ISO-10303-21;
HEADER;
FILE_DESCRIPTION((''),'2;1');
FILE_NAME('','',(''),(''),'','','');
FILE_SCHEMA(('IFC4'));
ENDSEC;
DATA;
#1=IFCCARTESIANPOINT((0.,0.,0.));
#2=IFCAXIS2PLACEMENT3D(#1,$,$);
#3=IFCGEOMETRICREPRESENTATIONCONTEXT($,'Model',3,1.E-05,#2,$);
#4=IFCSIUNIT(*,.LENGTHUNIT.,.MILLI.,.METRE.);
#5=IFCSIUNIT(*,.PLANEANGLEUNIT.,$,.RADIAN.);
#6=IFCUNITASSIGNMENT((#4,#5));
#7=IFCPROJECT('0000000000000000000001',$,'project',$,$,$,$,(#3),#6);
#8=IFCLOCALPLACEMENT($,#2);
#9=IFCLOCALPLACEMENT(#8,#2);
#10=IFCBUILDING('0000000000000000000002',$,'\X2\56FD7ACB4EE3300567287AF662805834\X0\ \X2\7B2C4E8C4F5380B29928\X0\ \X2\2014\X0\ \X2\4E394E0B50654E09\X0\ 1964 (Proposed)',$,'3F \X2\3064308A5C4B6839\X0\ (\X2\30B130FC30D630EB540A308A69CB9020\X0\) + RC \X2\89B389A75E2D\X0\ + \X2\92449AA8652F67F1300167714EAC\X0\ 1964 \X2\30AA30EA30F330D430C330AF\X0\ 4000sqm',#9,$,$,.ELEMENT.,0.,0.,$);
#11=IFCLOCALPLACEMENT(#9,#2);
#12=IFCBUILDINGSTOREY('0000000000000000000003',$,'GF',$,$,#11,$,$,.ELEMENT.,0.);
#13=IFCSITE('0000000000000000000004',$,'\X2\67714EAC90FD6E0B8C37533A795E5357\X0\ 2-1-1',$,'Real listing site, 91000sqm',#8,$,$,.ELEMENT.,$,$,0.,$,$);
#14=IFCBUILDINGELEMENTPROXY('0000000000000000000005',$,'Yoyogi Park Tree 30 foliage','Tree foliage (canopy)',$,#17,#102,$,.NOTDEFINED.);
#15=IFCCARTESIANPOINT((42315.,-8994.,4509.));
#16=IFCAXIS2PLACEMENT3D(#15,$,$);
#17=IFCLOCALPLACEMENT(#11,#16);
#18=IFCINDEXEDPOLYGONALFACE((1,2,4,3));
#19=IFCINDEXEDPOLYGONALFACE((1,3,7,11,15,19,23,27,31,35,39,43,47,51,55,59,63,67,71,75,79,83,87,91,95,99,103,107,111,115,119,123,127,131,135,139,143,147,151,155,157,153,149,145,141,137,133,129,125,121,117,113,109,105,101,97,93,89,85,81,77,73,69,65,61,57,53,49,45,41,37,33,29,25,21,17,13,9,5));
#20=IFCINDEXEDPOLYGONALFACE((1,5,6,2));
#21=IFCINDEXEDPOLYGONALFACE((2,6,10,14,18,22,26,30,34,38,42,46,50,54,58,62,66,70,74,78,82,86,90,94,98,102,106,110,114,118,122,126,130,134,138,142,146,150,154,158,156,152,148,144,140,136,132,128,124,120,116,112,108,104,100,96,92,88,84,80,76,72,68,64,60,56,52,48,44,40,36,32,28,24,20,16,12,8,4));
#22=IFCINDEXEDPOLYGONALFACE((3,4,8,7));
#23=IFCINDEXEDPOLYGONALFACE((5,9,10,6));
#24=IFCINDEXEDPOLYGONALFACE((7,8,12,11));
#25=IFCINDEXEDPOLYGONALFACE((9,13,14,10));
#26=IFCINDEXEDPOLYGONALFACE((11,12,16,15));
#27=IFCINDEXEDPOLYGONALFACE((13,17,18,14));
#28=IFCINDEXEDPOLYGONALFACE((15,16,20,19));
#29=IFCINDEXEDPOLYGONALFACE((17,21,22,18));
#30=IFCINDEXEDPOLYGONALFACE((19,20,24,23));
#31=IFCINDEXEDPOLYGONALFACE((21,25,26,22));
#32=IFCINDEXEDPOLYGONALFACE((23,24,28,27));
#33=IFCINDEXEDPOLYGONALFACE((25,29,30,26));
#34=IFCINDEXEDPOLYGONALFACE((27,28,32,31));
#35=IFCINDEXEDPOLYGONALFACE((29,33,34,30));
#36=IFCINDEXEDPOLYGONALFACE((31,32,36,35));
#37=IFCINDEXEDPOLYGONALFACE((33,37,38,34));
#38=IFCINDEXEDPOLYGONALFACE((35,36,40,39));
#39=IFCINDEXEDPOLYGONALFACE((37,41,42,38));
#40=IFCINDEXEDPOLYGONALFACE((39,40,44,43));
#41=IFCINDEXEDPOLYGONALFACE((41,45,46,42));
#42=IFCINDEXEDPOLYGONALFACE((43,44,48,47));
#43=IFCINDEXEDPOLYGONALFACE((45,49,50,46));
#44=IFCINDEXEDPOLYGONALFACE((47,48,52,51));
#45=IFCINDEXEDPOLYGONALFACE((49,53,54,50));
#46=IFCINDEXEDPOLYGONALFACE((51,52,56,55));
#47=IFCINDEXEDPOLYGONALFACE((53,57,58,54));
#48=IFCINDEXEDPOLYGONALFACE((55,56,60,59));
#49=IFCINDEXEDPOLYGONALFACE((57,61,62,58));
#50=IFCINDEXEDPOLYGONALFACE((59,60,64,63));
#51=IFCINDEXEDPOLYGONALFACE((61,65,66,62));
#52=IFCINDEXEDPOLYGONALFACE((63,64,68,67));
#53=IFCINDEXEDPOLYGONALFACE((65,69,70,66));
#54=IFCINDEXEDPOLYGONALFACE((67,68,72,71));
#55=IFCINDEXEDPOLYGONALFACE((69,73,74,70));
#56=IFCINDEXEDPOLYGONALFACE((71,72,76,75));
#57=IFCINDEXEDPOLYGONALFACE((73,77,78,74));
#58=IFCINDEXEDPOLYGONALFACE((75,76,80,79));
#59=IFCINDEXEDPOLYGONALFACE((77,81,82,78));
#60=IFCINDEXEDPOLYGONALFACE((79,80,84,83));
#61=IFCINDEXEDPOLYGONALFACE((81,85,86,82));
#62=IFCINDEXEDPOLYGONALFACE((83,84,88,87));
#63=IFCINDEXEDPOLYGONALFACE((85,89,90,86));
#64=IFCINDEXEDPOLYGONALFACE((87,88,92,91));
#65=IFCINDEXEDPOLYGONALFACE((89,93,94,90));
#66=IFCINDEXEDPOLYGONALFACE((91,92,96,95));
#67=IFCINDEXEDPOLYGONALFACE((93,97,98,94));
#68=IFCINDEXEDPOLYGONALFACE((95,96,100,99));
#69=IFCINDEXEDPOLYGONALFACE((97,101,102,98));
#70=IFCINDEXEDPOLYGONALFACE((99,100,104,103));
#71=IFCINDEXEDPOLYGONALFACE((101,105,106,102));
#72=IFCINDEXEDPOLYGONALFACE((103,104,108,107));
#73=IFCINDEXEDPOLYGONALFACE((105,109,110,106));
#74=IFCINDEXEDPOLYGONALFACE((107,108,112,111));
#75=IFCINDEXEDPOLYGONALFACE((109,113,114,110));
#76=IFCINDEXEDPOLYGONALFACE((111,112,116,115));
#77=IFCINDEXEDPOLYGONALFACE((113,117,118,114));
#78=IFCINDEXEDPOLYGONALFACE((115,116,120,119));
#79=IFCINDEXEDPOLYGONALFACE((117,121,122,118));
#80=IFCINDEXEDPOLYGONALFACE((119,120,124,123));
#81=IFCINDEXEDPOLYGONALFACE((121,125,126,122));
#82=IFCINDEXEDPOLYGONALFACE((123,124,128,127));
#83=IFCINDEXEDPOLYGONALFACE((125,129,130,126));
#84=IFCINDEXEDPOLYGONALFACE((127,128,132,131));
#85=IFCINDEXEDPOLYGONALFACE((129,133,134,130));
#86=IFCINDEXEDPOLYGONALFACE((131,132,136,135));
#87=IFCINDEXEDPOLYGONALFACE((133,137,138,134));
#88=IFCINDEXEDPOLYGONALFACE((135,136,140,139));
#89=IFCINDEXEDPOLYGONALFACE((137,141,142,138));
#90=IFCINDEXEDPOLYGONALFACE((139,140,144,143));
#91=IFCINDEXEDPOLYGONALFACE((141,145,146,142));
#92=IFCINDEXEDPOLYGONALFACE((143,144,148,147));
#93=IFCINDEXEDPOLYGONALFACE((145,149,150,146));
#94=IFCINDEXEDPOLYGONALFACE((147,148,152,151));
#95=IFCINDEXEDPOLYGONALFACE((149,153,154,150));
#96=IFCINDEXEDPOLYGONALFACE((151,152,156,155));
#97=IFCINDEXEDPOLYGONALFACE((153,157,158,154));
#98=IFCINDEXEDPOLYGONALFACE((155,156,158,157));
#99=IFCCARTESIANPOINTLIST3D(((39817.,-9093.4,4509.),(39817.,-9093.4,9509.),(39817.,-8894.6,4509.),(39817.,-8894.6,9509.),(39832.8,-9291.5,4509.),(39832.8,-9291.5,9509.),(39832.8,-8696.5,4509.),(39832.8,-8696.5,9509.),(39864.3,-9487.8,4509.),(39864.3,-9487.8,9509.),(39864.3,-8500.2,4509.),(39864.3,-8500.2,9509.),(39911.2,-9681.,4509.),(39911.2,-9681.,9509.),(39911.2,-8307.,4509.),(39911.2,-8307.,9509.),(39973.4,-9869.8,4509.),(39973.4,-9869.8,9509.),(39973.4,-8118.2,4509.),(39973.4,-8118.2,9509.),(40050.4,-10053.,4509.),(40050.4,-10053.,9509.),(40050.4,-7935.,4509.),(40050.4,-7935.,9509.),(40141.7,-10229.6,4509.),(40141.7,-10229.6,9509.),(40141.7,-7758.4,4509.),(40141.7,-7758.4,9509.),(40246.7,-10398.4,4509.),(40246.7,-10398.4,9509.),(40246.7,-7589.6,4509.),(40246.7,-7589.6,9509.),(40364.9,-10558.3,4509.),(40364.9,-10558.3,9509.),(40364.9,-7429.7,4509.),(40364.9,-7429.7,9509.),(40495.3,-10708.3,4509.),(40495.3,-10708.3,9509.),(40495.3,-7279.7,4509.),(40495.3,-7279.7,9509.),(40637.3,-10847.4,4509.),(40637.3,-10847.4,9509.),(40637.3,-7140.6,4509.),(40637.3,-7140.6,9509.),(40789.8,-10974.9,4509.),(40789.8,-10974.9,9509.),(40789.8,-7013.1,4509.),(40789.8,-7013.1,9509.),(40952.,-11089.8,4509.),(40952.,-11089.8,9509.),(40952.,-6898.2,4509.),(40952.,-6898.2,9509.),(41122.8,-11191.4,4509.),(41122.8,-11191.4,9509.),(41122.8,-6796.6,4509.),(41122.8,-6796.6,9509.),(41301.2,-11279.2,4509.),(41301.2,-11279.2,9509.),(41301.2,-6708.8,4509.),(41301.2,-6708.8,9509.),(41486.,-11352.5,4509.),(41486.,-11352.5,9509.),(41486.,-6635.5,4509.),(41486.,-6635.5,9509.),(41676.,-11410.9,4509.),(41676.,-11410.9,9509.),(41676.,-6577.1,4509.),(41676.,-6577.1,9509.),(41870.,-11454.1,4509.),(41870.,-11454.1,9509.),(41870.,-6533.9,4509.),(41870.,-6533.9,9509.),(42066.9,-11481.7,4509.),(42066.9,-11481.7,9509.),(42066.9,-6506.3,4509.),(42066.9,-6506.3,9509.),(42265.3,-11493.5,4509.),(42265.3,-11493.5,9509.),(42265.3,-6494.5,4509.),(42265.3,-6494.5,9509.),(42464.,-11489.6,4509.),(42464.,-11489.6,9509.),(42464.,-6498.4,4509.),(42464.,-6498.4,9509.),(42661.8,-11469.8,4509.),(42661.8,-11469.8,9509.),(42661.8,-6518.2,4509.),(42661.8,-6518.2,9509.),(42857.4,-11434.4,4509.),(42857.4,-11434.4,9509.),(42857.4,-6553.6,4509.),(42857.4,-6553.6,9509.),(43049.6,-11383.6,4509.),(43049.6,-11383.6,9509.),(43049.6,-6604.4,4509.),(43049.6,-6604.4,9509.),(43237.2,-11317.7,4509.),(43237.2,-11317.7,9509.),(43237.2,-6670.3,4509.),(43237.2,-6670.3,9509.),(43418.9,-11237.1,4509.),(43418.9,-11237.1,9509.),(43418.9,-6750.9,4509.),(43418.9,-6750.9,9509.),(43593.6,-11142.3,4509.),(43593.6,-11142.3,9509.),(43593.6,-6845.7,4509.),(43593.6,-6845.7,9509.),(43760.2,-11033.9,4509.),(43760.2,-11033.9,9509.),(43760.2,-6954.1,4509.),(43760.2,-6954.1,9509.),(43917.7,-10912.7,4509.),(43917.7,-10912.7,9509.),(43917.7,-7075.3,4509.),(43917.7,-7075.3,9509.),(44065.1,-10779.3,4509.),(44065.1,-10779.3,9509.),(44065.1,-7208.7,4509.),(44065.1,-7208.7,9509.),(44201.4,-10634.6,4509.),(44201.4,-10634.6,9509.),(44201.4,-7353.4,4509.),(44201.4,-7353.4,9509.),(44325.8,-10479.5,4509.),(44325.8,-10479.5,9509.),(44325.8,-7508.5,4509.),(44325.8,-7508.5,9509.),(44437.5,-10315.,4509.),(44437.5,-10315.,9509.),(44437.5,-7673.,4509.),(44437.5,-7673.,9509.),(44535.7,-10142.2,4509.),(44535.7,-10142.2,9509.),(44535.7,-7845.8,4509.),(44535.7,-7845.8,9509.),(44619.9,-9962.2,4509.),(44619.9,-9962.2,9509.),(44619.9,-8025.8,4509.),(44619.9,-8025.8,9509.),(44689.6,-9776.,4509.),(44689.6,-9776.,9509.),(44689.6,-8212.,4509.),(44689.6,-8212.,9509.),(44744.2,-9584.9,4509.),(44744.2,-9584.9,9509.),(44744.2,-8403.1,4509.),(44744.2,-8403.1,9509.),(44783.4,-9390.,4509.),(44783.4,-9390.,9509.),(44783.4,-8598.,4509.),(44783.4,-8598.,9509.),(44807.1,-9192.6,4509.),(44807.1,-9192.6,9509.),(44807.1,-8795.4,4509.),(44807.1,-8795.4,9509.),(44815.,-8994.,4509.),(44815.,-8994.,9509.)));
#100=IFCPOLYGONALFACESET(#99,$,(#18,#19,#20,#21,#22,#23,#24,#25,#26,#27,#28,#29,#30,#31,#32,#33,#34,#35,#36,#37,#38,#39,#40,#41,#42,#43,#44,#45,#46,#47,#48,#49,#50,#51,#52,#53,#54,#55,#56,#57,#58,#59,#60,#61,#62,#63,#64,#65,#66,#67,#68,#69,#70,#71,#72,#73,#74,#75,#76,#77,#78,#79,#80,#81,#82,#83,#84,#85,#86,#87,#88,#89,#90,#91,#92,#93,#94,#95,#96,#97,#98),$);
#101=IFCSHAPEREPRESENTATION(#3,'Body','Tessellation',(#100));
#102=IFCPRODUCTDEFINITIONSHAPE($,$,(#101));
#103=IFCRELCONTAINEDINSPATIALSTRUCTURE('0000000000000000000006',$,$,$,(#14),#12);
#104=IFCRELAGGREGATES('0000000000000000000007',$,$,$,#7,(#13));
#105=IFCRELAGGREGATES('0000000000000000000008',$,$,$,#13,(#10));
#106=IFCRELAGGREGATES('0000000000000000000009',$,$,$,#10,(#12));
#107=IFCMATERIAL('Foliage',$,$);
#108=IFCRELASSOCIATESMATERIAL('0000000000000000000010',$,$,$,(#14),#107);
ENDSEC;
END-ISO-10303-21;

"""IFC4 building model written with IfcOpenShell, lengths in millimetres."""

from ifc_helpers import new_model, si_unit, frame, origin, origin_2d, place, context, project, spatial, circle, extrude, material, element, save


model = new_model("IFC4")

# Units and contexts
model_context = context("Model", 3, precision=1e-05, world=origin())
ifc_project = project(units=[si_unit("LENGTHUNIT", "METRE", prefix="MILLI"), si_unit("PLANEANGLEUNIT", "RADIAN")], contexts=[model_context])

# Site, building, storey
site_placement = place(None, origin())
site = spatial("IfcSite", under=ifc_project, at=site_placement, Name="東京都渋谷区神南 2-1-1", ObjectType="Real listing site, 91000sqm", CompositionType="ELEMENT", RefElevation=0.0)
building_placement = place(site_placement, origin())
building = spatial("IfcBuilding", under=site, at=building_placement, Name="国立代々木競技場 第二体育館 — 丹下健三 1964 (Proposed)", ObjectType="3F つり屋根 (ケーブル吊り構造) + RC 観覧席 + 鉄骨支柱、東京 1964 オリンピック 4000sqm", CompositionType="ELEMENT", ElevationOfRefHeight=0.0, ElevationOfTerrain=0.0)
storey_placement = place(building_placement, origin())
storey = spatial("IfcBuildingStorey", under=building, at=storey_placement, Name="GF", CompositionType="ELEMENT", Elevation=0.0)

# Building element proxy
ifc_material_1 = material(Name="Foliage")
proxy_1_placement = place(storey_placement, frame((42315.0, -8994.0, 4509.0)))
element("IfcBuildingElementProxy", 1, at=proxy_1_placement, inside=storey, material=ifc_material_1, Name="Yoyogi Park Tree 30 foliage", Description="Tree foliage (canopy)", PredefinedType="NOTDEFINED", context=model_context, shape_type="SweptSolid", body=[
    extrude(circle(Radius=2500.0, at=origin_2d()), frame((42315.0, -8994.0, 4509.0)), (0.0, 0.0, 1.0), 5000.0),
])

save(model, "model.ifc")
